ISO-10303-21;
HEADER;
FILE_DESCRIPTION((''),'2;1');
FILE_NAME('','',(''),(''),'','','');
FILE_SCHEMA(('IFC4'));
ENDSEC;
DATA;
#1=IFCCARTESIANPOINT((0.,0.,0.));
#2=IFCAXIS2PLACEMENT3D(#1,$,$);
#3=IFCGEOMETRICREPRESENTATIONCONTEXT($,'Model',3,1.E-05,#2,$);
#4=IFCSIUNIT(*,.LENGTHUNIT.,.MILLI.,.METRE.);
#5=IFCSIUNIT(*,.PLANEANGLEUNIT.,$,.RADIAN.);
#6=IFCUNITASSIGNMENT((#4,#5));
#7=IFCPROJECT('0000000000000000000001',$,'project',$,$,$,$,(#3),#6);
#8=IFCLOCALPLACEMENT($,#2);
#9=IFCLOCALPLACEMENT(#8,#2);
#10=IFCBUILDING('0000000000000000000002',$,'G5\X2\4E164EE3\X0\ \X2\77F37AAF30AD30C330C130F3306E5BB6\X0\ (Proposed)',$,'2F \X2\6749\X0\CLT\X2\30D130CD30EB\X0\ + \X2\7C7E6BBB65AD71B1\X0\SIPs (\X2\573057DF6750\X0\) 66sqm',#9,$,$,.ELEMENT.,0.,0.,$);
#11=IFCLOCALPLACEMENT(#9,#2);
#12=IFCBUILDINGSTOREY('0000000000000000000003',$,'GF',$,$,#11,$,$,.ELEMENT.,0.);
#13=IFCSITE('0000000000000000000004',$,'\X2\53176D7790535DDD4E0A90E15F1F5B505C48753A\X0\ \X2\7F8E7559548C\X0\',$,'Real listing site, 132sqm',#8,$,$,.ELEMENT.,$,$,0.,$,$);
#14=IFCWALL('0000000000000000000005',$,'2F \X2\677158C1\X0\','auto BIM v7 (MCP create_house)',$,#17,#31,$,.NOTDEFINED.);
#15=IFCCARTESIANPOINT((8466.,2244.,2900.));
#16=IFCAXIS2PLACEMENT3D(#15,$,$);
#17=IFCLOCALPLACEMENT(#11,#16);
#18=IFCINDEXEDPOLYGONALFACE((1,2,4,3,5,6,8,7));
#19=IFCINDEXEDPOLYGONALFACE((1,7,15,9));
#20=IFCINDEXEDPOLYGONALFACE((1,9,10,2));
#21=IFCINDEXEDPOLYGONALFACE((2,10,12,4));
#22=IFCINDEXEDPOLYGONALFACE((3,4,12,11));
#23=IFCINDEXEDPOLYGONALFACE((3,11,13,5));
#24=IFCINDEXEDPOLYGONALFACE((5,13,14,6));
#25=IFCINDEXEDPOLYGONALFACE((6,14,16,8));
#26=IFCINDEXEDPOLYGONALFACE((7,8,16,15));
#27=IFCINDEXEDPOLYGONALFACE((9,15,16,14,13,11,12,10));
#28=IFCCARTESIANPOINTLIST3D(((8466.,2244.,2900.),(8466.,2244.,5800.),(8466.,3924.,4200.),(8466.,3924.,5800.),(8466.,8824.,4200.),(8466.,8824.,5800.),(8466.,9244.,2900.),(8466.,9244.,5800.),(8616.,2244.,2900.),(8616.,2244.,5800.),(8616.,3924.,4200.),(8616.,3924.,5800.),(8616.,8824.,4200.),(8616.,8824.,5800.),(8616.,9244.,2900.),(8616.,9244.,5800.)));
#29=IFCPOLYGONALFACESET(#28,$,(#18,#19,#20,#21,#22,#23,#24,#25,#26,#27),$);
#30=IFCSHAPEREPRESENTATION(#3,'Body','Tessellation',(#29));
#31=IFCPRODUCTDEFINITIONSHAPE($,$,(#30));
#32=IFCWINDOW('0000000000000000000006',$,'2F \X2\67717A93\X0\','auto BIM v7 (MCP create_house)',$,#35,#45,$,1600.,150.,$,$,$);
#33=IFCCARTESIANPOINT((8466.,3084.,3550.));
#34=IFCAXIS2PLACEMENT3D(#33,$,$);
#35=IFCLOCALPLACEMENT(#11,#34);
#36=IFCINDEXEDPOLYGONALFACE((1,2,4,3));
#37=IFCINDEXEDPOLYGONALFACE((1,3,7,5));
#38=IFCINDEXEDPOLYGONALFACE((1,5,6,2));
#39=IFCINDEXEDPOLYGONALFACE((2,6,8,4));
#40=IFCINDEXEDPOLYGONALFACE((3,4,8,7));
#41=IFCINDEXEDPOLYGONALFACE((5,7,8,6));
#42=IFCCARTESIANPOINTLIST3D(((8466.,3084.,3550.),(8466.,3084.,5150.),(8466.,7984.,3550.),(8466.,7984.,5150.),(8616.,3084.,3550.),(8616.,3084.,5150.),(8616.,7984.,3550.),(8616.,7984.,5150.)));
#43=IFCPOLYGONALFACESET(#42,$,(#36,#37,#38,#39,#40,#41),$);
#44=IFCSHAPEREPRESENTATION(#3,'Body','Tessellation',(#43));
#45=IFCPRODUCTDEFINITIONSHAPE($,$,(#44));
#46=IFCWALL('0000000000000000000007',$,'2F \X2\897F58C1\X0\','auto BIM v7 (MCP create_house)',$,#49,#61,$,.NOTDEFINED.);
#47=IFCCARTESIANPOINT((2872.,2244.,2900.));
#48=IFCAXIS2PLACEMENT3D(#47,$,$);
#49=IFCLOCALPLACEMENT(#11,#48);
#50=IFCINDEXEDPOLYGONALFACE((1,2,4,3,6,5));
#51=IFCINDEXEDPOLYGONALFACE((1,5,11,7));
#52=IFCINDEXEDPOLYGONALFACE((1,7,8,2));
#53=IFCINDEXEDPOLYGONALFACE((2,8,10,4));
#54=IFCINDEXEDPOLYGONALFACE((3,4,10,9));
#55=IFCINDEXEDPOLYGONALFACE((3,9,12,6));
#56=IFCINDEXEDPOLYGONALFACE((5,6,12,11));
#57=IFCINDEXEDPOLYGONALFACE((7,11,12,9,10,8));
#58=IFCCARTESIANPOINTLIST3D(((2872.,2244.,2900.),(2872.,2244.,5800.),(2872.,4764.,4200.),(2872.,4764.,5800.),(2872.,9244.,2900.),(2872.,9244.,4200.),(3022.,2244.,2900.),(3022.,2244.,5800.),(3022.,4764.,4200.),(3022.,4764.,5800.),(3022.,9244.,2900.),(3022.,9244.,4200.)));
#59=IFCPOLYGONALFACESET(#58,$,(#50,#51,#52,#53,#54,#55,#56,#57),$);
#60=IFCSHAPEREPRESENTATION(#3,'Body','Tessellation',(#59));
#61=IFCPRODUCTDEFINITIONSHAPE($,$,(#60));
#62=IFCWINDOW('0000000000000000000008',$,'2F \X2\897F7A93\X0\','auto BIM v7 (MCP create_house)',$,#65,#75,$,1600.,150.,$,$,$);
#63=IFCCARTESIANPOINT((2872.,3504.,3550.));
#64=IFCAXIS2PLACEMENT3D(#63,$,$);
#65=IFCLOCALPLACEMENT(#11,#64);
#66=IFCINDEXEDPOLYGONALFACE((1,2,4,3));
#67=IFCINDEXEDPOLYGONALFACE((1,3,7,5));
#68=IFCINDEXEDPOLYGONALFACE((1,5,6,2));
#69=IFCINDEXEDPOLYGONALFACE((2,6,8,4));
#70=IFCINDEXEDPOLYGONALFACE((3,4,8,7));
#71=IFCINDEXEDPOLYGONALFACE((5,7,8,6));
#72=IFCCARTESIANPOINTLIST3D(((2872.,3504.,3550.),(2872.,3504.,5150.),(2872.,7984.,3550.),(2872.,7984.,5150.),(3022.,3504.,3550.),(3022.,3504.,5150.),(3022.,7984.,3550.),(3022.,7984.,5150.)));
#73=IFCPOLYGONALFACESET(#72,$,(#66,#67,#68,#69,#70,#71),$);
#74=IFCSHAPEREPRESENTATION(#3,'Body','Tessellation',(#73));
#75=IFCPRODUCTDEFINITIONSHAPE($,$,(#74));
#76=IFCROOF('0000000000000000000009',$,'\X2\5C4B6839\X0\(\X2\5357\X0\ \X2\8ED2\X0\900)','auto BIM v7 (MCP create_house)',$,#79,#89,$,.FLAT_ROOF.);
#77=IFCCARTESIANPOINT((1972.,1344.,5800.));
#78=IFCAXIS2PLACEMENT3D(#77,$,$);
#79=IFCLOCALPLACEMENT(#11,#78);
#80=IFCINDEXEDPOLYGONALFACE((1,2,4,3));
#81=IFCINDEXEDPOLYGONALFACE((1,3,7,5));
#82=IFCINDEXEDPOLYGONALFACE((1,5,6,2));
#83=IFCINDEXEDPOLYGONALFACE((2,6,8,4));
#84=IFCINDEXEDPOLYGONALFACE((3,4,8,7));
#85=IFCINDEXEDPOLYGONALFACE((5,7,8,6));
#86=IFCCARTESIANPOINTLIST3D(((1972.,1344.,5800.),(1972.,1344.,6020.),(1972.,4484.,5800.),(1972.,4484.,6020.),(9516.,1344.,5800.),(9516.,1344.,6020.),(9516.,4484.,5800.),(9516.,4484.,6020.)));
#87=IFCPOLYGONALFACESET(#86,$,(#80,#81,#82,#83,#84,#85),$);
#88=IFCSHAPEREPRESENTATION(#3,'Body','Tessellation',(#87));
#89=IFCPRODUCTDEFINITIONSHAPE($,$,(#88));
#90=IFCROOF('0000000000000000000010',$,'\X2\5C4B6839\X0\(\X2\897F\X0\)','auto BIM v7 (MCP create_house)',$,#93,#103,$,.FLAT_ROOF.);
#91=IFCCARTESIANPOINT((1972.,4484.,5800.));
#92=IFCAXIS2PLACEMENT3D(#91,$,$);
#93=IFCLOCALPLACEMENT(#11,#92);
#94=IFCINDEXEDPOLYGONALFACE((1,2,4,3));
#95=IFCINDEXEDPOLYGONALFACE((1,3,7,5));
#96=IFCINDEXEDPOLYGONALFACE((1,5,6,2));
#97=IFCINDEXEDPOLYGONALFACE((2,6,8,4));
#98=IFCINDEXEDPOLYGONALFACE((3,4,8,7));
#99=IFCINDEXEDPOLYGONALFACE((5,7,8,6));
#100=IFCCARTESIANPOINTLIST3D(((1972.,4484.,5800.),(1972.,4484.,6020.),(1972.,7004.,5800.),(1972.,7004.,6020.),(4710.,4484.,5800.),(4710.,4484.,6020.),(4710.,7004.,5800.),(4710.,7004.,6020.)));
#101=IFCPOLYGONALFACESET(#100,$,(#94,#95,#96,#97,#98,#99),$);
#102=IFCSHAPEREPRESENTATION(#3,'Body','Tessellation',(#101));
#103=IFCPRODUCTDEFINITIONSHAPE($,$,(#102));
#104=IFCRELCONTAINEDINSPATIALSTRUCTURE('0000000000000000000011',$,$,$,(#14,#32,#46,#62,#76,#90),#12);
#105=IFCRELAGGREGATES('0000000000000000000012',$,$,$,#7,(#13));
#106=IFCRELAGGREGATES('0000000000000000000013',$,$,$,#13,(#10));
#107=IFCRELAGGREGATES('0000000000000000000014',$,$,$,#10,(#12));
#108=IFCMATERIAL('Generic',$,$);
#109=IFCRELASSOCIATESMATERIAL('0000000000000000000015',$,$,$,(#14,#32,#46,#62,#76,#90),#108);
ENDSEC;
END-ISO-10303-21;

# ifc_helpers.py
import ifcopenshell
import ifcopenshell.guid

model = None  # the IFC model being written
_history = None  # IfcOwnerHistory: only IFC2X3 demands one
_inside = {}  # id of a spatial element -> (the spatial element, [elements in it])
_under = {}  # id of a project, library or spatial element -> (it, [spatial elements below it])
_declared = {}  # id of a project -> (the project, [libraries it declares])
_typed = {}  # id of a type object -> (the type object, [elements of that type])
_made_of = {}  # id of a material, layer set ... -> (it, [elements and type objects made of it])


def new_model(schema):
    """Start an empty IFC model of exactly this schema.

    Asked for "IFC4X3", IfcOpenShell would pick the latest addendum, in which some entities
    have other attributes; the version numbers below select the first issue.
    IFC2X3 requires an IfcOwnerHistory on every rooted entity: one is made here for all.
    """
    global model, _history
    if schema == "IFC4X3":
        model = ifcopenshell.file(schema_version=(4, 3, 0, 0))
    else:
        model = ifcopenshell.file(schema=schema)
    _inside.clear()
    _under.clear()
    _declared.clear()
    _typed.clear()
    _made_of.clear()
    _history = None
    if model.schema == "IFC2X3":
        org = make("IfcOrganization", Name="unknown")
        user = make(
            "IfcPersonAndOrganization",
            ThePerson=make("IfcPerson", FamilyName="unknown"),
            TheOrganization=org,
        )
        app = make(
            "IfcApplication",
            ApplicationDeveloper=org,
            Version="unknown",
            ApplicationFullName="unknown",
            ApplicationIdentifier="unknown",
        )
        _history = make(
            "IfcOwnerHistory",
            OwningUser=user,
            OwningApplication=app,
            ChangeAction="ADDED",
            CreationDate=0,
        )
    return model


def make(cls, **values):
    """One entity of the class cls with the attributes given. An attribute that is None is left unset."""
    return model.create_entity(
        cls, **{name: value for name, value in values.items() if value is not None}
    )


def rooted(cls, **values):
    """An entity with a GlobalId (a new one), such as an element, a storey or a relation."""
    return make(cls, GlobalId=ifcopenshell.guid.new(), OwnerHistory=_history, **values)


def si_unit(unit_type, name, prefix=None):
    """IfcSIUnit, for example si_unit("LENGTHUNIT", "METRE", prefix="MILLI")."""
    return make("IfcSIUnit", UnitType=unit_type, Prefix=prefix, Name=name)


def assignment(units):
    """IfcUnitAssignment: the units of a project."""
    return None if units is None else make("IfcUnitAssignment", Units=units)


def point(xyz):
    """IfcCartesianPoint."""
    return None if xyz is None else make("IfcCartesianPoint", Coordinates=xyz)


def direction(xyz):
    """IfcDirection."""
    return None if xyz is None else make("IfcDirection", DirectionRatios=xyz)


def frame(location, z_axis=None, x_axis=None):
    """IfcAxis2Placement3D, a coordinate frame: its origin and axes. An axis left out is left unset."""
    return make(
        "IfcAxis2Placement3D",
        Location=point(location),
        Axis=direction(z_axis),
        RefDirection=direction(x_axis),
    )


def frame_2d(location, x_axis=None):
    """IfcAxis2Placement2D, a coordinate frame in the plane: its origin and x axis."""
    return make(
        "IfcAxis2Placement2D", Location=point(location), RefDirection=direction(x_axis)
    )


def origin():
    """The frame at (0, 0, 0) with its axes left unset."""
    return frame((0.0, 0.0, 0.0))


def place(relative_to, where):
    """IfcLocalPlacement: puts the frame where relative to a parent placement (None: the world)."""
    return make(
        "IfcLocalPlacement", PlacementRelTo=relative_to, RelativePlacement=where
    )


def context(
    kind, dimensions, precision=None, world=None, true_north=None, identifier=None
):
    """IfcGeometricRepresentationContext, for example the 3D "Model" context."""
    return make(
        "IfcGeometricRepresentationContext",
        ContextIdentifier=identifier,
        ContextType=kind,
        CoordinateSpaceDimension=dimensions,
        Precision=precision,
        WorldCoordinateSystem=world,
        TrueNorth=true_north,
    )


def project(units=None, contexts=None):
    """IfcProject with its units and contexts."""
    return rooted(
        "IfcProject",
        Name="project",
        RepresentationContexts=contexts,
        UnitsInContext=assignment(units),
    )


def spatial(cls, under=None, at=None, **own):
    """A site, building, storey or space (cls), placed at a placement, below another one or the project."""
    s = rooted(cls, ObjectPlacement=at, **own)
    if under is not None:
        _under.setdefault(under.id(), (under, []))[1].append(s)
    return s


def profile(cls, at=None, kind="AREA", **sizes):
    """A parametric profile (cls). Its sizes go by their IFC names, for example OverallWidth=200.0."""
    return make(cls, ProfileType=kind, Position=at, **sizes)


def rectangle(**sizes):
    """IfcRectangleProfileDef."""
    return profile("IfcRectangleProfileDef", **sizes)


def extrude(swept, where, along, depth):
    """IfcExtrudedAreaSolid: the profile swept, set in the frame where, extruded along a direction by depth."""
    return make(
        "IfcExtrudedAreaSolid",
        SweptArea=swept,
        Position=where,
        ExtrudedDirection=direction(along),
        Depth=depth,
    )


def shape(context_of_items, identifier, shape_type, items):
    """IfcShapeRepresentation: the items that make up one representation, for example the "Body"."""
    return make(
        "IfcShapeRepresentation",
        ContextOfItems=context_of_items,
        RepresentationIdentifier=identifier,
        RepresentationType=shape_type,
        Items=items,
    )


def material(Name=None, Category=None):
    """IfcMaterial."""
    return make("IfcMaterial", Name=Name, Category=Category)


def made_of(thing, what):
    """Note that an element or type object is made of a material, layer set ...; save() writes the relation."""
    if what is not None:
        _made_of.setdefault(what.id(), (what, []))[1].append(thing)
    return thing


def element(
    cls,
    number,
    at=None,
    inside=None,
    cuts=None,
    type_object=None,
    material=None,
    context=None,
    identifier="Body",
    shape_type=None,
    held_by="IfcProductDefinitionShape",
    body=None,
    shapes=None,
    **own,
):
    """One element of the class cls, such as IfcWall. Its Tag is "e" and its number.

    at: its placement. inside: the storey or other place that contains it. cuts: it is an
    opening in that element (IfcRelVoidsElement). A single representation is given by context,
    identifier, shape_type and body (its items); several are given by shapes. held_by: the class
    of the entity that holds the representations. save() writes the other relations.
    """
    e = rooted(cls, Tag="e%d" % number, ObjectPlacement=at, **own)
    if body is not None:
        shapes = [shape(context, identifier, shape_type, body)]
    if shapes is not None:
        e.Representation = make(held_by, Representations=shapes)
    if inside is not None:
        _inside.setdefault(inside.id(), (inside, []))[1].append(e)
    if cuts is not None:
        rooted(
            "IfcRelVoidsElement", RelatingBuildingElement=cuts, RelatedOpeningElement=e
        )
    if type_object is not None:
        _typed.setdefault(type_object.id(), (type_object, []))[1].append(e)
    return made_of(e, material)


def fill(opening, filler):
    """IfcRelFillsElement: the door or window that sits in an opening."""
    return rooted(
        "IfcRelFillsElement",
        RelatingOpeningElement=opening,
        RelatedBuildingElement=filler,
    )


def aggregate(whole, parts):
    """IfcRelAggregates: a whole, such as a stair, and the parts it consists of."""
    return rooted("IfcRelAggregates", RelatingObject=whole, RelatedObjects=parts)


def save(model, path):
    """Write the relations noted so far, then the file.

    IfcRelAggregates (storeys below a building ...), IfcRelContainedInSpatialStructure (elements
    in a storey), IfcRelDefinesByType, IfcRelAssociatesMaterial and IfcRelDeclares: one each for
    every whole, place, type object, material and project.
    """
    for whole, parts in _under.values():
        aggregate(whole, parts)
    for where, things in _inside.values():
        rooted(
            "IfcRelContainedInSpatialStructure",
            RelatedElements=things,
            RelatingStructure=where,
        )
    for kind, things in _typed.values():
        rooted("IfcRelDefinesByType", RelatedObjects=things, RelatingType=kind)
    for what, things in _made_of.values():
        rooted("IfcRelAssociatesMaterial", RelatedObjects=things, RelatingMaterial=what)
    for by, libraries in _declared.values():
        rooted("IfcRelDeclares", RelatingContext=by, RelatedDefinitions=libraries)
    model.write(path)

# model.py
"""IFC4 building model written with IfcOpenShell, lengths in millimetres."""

from ifc_helpers import new_model, si_unit, frame, frame_2d, origin, place, context, project, spatial, rectangle, extrude, material, element, fill, save


model = new_model("IFC4")

# Units and contexts
model_context = context("Model", 3, precision=1e-05, world=origin())
ifc_project = project(units=[si_unit("LENGTHUNIT", "METRE", prefix="MILLI"), si_unit("PLANEANGLEUNIT", "RADIAN")], contexts=[model_context])

# Site, building, storey
site_placement = place(None, origin())
site = spatial("IfcSite", under=ifc_project, at=site_placement, Name="北海道川上郡弟子屈町 美留和", ObjectType="Real listing site, 132sqm", CompositionType="ELEMENT", RefElevation=0.0)
building_placement = place(site_placement, origin())
building = spatial("IfcBuilding", under=site, at=building_placement, Name="G5世代 石窯キッチンの家 (Proposed)", ObjectType="2F 杉CLTパネル + 籾殻断熱SIPs (地域材) 66sqm", CompositionType="ELEMENT", ElevationOfRefHeight=0.0, ElevationOfTerrain=0.0)
storey_placement = place(building_placement, origin())
storey = spatial("IfcBuildingStorey", under=building, at=storey_placement, Name="GF", CompositionType="ELEMENT", Elevation=0.0)

# Shared definitions
ifc_material = material(Name="Generic")

# Walls, openings, windows
wall_1_placement = place(storey_placement, frame((8466.0, 2244.0, 2900.0)))
wall_1 = element("IfcWall", 1, at=wall_1_placement, inside=storey, material=ifc_material, Name="2F 東壁", Description="auto BIM v7 (MCP create_house)", PredefinedType="NOTDEFINED", context=model_context, shape_type="SweptSolid", body=[
    extrude(rectangle(XDim=150.0, YDim=7000.0, at=frame_2d((75.0, 3500.0))), frame((8466.0, 2244.0, 2900.0)), (0.0, 0.0, 1.0), 2900.0),
])
opening_1_placement = place(storey_placement, frame((8466.0, 3084.0, 3550.0)))
opening_1 = element("IfcOpeningElement", 2, at=opening_1_placement, cuts=wall_1, PredefinedType="NOTDEFINED", context=model_context, shape_type="SweptSolid", body=[
    extrude(rectangle(XDim=150.0, YDim=4900.0, at=frame_2d((75.0, 2450.0))), frame((8466.0, 3084.0, 3550.0)), (0.0, 0.0, 1.0), 1600.0),
])
window_1_placement = place(storey_placement, frame((8466.0, 3084.0, 3550.0)))
window_1 = element("IfcWindow", 3, at=window_1_placement, inside=storey, material=ifc_material, Name="2F 東窓", Description="auto BIM v7 (MCP create_house)", OverallHeight=1600.0, OverallWidth=150.0, context=model_context, shape_type="SweptSolid", body=[
    extrude(rectangle(XDim=150.0, YDim=4900.0, at=frame_2d((75.0, 2450.0))), frame((8466.0, 3084.0, 3550.0)), (0.0, 0.0, 1.0), 1600.0),
])
fill(opening_1, window_1)
wall_2_placement = place(storey_placement, frame((2872.0, 2244.0, 2900.0)))
wall_2 = element("IfcWall", 4, at=wall_2_placement, inside=storey, material=ifc_material, Name="2F 西壁", Description="auto BIM v7 (MCP create_house)", PredefinedType="NOTDEFINED", context=model_context, shape_type="SweptSolid", body=[
    extrude(rectangle(XDim=150.0, YDim=7000.0, at=frame_2d((75.0, 3500.0))), frame((2872.0, 2244.0, 2900.0)), (0.0, 0.0, 1.0), 2900.0),
])
opening_2_placement = place(storey_placement, frame((2872.0, 3504.0, 3550.0)))
opening_2 = element("IfcOpeningElement", 5, at=opening_2_placement, cuts=wall_2, PredefinedType="NOTDEFINED", context=model_context, shape_type="SweptSolid", body=[
    extrude(rectangle(XDim=150.0, YDim=4480.0, at=frame_2d((75.0, 2240.0))), frame((2872.0, 3504.0, 3550.0)), (0.0, 0.0, 1.0), 1600.0),
])
window_2_placement = place(storey_placement, frame((2872.0, 3504.0, 3550.0)))
window_2 = element("IfcWindow", 6, at=window_2_placement, inside=storey, material=ifc_material, Name="2F 西窓", Description="auto BIM v7 (MCP create_house)", OverallHeight=1600.0, OverallWidth=150.0, context=model_context, shape_type="SweptSolid", body=[
    extrude(rectangle(XDim=150.0, YDim=4480.0, at=frame_2d((75.0, 2240.0))), frame((2872.0, 3504.0, 3550.0)), (0.0, 0.0, 1.0), 1600.0),
])
fill(opening_2, window_2)

# Roofs
roof_1_placement = place(storey_placement, frame((1972.0, 1344.0, 5800.0)))
element("IfcRoof", 7, at=roof_1_placement, inside=storey, material=ifc_material, Name="屋根(南 軒900)", Description="auto BIM v7 (MCP create_house)", PredefinedType="FLAT_ROOF", context=model_context, shape_type="SweptSolid", body=[
    extrude(rectangle(XDim=7544.0, YDim=3140.0, at=frame_2d((3772.0, 1570.0))), frame((1972.0, 1344.0, 5800.0)), (0.0, 0.0, 1.0), 220.0),
])
roof_2_placement = place(storey_placement, frame((1972.0, 4484.0, 5800.0)))
element("IfcRoof", 8, at=roof_2_placement, inside=storey, material=ifc_material, Name="屋根(西)", Description="auto BIM v7 (MCP create_house)", PredefinedType="FLAT_ROOF", context=model_context, shape_type="SweptSolid", body=[
    extrude(rectangle(XDim=2738.0, YDim=2520.0, at=frame_2d((1369.0, 1260.0))), frame((1972.0, 4484.0, 5800.0)), (0.0, 0.0, 1.0), 220.0),
])

save(model, "model.ifc")
